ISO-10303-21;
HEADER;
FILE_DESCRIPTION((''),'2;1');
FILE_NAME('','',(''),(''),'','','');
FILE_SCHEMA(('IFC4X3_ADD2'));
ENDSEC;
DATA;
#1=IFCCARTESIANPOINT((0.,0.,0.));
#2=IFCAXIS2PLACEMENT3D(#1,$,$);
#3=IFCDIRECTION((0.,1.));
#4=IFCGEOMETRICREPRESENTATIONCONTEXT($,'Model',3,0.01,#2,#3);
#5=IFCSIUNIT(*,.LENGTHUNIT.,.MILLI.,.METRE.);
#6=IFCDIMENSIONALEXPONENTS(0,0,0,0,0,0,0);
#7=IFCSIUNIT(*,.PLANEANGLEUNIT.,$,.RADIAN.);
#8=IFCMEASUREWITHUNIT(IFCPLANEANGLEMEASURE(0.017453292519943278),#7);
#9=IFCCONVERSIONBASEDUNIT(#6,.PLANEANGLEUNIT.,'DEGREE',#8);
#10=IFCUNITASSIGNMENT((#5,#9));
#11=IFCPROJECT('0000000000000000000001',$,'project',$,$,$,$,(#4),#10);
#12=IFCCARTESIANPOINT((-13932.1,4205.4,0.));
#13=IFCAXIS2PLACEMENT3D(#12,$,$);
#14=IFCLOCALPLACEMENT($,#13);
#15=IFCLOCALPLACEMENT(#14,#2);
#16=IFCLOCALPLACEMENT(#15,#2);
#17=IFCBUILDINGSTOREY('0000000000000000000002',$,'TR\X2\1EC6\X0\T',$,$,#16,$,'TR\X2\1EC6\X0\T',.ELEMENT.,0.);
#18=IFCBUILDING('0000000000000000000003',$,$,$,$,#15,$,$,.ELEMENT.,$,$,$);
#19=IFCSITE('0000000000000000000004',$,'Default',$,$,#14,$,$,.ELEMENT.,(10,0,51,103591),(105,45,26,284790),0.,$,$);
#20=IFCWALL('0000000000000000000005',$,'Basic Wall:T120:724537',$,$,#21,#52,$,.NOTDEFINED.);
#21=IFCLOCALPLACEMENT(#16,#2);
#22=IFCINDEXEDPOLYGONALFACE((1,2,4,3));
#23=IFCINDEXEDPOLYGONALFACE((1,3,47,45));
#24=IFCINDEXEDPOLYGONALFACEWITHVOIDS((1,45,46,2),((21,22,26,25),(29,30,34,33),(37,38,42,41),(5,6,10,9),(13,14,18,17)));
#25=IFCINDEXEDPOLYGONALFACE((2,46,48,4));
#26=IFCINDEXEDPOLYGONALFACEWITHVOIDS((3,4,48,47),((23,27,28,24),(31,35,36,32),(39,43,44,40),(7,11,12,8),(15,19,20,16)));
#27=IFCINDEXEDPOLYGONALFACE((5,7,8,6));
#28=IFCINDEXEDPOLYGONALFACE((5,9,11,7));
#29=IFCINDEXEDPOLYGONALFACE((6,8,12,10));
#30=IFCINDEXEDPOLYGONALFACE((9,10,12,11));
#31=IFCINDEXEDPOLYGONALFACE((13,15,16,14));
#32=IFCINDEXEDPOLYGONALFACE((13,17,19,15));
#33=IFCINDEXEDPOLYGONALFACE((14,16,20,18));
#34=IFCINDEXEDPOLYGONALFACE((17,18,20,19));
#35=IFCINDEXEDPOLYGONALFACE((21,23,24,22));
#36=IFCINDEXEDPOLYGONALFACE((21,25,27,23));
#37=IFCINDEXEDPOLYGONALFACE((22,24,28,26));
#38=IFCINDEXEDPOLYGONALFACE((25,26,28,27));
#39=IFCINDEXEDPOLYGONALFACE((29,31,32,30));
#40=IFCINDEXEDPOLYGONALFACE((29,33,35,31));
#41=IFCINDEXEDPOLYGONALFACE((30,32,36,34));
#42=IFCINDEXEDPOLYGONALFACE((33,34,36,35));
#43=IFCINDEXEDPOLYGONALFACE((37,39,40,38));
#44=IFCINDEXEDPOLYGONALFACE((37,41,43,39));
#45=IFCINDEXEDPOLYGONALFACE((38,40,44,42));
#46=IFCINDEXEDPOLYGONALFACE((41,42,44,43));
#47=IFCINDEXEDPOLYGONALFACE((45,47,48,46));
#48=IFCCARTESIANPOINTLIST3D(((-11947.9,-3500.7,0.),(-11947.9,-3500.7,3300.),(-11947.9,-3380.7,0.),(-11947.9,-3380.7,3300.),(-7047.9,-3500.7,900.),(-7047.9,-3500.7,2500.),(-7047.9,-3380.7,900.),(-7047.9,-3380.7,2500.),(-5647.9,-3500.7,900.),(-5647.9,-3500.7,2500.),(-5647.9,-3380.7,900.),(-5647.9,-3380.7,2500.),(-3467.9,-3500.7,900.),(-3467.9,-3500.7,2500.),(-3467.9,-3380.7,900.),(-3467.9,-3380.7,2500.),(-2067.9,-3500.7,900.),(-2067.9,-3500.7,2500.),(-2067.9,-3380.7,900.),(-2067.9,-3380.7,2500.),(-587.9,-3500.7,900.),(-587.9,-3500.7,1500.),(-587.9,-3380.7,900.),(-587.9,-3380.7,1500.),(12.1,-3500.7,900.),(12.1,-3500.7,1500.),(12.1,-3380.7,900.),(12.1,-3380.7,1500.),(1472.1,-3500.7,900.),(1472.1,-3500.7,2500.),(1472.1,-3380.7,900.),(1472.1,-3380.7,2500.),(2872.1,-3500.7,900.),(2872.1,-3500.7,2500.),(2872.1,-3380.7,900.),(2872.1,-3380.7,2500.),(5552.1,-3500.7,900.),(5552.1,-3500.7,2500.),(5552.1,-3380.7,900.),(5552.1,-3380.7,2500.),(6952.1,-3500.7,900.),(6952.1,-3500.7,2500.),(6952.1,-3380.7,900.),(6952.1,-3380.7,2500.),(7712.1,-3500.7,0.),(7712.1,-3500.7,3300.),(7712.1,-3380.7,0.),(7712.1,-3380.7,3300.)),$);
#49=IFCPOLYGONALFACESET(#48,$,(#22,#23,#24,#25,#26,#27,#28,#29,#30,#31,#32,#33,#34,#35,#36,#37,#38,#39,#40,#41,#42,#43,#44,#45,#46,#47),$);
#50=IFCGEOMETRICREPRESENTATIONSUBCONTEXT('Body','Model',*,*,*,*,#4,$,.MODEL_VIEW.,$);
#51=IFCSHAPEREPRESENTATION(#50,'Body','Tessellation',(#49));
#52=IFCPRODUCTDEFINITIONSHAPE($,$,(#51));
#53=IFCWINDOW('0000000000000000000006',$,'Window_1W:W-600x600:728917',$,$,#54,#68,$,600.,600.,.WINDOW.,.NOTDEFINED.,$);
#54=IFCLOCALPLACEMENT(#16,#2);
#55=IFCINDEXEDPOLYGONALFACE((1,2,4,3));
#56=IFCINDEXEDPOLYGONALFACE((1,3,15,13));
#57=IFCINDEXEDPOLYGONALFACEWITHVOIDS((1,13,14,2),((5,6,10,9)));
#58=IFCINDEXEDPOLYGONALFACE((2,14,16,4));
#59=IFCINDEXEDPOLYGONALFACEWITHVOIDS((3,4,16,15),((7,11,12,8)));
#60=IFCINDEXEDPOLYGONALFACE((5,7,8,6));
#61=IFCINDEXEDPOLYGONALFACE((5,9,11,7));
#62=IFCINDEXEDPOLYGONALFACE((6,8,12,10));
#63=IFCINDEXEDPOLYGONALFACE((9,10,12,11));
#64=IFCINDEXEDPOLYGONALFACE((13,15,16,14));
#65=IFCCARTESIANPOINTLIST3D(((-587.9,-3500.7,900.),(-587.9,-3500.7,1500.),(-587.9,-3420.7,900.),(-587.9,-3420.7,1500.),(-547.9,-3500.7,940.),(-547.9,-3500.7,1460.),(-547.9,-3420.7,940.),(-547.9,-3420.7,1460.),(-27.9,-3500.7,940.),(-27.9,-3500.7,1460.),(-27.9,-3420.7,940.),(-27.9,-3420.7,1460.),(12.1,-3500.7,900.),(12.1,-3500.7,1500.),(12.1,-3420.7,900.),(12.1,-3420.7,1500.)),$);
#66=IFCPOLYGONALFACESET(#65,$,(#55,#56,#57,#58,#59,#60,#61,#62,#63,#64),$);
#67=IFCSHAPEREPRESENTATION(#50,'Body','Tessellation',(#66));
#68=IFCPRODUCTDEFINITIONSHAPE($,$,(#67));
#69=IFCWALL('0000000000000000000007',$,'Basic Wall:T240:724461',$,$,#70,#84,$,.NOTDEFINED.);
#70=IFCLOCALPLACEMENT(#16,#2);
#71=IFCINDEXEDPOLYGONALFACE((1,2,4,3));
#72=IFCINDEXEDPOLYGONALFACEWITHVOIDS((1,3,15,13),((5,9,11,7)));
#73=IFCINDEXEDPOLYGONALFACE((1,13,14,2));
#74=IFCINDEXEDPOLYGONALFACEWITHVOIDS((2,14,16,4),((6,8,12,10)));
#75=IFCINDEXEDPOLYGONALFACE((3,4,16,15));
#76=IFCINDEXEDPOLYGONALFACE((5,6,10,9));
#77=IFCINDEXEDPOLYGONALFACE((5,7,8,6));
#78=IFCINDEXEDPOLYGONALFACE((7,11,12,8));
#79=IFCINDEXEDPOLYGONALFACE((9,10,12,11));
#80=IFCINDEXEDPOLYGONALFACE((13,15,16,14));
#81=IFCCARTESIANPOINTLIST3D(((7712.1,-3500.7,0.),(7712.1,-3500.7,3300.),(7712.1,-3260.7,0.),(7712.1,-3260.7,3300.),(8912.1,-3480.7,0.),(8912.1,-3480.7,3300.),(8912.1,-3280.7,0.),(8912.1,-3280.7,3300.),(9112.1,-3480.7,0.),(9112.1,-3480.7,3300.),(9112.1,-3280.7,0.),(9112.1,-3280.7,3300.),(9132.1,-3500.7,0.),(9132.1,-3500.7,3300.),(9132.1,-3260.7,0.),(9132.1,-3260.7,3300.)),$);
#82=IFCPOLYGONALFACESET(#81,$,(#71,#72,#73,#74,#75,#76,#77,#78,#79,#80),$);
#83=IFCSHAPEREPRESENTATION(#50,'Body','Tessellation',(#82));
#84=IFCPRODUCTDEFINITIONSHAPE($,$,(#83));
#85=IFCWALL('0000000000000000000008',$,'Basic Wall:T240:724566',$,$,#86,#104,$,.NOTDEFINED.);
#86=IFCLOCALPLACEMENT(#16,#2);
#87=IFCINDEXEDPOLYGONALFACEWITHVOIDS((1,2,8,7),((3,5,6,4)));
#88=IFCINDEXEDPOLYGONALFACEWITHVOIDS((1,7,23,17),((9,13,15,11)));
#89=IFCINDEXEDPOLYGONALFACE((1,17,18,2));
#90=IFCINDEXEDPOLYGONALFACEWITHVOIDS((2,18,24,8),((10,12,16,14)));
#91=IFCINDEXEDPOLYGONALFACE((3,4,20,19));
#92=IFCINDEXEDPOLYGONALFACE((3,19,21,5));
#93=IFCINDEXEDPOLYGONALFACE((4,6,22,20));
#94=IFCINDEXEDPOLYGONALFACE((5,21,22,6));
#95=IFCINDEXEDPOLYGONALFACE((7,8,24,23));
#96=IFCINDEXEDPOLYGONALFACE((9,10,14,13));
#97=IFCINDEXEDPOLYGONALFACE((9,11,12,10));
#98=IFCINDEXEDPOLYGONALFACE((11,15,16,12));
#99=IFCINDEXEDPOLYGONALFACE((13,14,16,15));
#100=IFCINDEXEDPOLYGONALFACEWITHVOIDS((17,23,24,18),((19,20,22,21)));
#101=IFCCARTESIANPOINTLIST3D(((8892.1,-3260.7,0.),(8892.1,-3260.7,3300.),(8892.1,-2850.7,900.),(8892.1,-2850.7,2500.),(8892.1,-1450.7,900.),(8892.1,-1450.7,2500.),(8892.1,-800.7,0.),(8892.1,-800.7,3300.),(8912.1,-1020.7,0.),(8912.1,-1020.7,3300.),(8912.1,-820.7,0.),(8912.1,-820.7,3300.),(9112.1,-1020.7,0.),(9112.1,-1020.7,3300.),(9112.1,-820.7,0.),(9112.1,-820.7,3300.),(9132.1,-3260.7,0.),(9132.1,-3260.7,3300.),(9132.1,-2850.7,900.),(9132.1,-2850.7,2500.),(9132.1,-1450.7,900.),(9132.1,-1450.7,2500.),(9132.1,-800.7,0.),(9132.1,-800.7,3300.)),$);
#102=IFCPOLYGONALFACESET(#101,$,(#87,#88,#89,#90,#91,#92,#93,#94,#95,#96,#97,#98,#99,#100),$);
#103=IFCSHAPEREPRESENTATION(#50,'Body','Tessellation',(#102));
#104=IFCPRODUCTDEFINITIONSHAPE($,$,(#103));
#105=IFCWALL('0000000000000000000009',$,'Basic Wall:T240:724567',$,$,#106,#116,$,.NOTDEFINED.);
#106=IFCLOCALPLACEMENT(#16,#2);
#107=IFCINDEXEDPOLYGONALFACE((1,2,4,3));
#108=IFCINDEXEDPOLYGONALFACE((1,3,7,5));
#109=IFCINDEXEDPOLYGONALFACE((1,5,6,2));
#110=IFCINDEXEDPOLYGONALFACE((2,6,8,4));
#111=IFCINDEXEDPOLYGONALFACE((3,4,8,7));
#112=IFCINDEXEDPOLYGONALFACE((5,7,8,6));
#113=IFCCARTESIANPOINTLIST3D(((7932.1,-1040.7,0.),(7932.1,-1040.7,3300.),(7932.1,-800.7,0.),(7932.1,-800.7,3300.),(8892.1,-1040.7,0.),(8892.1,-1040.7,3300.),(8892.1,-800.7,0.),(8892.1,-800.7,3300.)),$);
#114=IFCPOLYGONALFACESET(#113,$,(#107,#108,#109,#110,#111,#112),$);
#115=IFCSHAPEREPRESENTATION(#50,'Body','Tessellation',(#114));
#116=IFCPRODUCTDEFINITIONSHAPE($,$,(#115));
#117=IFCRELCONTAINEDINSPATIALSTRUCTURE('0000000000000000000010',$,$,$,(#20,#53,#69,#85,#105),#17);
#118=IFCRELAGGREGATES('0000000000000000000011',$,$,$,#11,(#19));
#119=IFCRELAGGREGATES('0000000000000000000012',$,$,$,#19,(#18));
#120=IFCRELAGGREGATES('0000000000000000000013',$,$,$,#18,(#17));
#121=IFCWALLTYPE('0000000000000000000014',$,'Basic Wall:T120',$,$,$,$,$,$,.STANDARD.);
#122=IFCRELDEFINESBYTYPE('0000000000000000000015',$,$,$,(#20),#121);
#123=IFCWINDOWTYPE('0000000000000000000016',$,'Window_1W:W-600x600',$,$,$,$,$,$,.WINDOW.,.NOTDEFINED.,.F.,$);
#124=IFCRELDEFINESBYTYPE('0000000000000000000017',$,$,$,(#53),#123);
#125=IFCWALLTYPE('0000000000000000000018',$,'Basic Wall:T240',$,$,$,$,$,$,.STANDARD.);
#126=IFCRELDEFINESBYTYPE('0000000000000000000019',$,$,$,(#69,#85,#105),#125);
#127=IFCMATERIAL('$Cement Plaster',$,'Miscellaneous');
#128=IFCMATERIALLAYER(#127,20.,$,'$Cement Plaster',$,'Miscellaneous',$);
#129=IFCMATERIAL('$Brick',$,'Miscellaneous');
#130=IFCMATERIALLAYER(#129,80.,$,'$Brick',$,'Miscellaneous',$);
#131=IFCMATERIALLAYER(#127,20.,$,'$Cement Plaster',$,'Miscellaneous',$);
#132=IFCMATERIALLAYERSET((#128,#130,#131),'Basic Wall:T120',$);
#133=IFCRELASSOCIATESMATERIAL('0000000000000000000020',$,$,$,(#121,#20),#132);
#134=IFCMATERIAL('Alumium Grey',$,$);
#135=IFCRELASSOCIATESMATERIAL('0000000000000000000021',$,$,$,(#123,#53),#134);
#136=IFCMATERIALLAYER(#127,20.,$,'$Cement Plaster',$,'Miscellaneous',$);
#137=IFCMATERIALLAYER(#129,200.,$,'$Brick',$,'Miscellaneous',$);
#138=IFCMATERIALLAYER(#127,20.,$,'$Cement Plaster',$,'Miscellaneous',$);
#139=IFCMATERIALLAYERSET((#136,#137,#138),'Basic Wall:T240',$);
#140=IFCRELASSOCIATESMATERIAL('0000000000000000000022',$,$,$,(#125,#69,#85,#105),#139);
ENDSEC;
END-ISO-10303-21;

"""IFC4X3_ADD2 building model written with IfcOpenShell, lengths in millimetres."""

from ifc_helpers import new_model, entity, si_unit, converted_unit, direction, frame, frame_2d, origin, origin_2d_with_axis, place, context, subcontext, project, spatial, polyline, rectangle, outline, extrude, source, transform, mapped, material, layer, layer_set, type_object, type_shapes, element, fill, save


model = new_model("IFC4X3_ADD2")

# Units and contexts
model_context = context("Model", 3, precision=0.01, world=origin(), true_north=direction((0.0, 1.0)))
body_context = subcontext(model_context, "Body", "Model", "MODEL_VIEW")
ifc_project = project(units=[si_unit("LENGTHUNIT", "METRE", prefix="MILLI"), converted_unit("PLANEANGLEUNIT", "DEGREE", entity("IfcPlaneAngleMeasure", 0.017453292519943278), si_unit("PLANEANGLEUNIT", "RADIAN"), dimensions=[0, 0, 0, 0, 0, 0, 0])], contexts=[model_context])

# Site, building, storey
site_placement = place(None, frame((-13932.1, 4205.4, 0.0)))
site = spatial("IfcSite", under=ifc_project, at=site_placement, Name="Default", CompositionType="ELEMENT", RefLatitude=(10, 0, 51, 103591), RefLongitude=(105, 45, 26, 284790), RefElevation=0.0)
building_placement = place(site_placement, origin())
building = spatial("IfcBuilding", under=site, at=building_placement, CompositionType="ELEMENT")
storey_placement = place(building_placement, origin())
storey = spatial("IfcBuildingStorey", under=building, at=storey_placement, Name="TRỆT", LongName="TRỆT", CompositionType="ELEMENT", Elevation=0.0)

# Shared definitions
ifc_material_1 = material(Name="$Cement Plaster", Category="Miscellaneous")
ifc_layer_1 = layer(ifc_material_1, 20.0, Name="$Cement Plaster", Category="Miscellaneous")
ifc_material_2 = material(Name="$Brick", Category="Miscellaneous")
ifc_layer_2 = layer(ifc_material_2, 80.0, Name="$Brick", Category="Miscellaneous")
ifc_layer_3 = layer(ifc_material_1, 20.0, Name="$Cement Plaster", Category="Miscellaneous")
ifc_layer_set_1 = layer_set([ifc_layer_1, ifc_layer_2, ifc_layer_3], Name="Basic Wall:T120")
wall_type_1 = type_object("IfcWallType", Name="Basic Wall:T120", PredefinedType="STANDARD", material=ifc_layer_set_1)

# Wall, openings, window
wall_1_placement = place(storey_placement, frame((7712.1, -3440.7, 0.0), z_axis=(0.0, 0.0, 1.0), x_axis=(-1.0, 0.0, 0.0)))
wall_1 = element("IfcWall", 1, at=wall_1_placement, inside=storey, type_object=wall_type_1, material=ifc_layer_set_1, Name="Basic Wall:T120:724537", PredefinedType="NOTDEFINED", context=body_context, shape_type="SweptSolid", body=[
    extrude(rectangle(XDim=19660.0, YDim=120.0, at=frame_2d((9830.0, 0.0), x_axis=(-1.0, 0.0))), origin(), (0.0, 0.0, 1.0), 3300.0),
])
opening_1_placement = place(wall_1_placement, frame((9780.0, -60.0, 900.0)))
element("IfcOpeningElement", 2, at=opening_1_placement, cuts=wall_1, PredefinedType="OPENING", context=body_context, shape_type="SweptSolid", body=[
    extrude(rectangle(XDim=1600.0, YDim=1400.0, at=frame_2d((800.0, 700.0), x_axis=(1.0, 0.0))), frame((0.0, 0.0, 0.0), z_axis=(0.0, 1.0, 0.0), x_axis=(0.0, 0.0, 1.0)), (0.0, 0.0, 1.0), 120.0),
])
opening_2_placement = place(wall_1_placement, frame((13360.0, -60.0, 900.0)))
element("IfcOpeningElement", 3, at=opening_2_placement, cuts=wall_1, PredefinedType="OPENING", context=body_context, shape_type="SweptSolid", body=[
    extrude(rectangle(XDim=1600.0, YDim=1400.0, at=frame_2d((800.0, 700.0), x_axis=(1.0, 0.0))), frame((0.0, 0.0, 0.0), z_axis=(0.0, 1.0, 0.0), x_axis=(0.0, 0.0, 1.0)), (0.0, 0.0, 1.0), 120.0),
])
opening_3_placement = place(wall_1_placement, frame((4840.0, -60.0, 900.0)))
element("IfcOpeningElement", 4, at=opening_3_placement, cuts=wall_1, PredefinedType="OPENING", context=body_context, shape_type="SweptSolid", body=[
    extrude(rectangle(XDim=1600.0, YDim=1400.0, at=frame_2d((800.0, 700.0), x_axis=(1.0, 0.0))), frame((0.0, 0.0, 0.0), z_axis=(0.0, 1.0, 0.0), x_axis=(0.0, 0.0, 1.0)), (0.0, 0.0, 1.0), 120.0),
])
opening_4_placement = place(wall_1_placement, frame((760.0, -60.0, 900.0)))
element("IfcOpeningElement", 5, at=opening_4_placement, cuts=wall_1, PredefinedType="OPENING", context=body_context, shape_type="SweptSolid", body=[
    extrude(rectangle(XDim=1600.0, YDim=1400.0, at=frame_2d((800.0, 700.0), x_axis=(1.0, 0.0))), frame((0.0, 0.0, 0.0), z_axis=(0.0, 1.0, 0.0), x_axis=(0.0, 0.0, 1.0)), (0.0, 0.0, 1.0), 120.0),
])
opening_5_placement = place(wall_1_placement, frame((7700.0, -60.0, 900.0)))
opening_5 = element("IfcOpeningElement", 6, at=opening_5_placement, cuts=wall_1, PredefinedType="OPENING", context=body_context, shape_type="SweptSolid", body=[
    extrude(rectangle(XDim=600.0, YDim=600.0, at=frame_2d((300.0, 300.0), x_axis=(1.0, 0.0))), frame((0.0, 0.0, 0.0), z_axis=(0.0, 1.0, 0.0), x_axis=(0.0, 0.0, 1.0)), (0.0, 0.0, 1.0), 120.0),
])
ifc_material_3 = material(Name="Alumium Grey")
window_type = type_object("IfcWindowType", Name="Window_1W:W-600x600", ParameterTakesPrecedence=False, PartitioningType="NOTDEFINED", PredefinedType="WINDOW", material=ifc_material_3)
shared_shape_1 = source(origin(), body_context, "Body", "SweptSolid", [
    extrude(outline(polyline([(-300.0, -300.0), (300.0, -300.0), (300.0, 300.0), (-300.0, 300.0), (-300.0, -300.0)]), holes=[polyline([(-260.0, -260.0), (-260.0, 260.0), (260.0, 260.0), (260.0, -260.0), (-260.0, -260.0)])]), frame((300.0, 120.0, 300.0), z_axis=(0.0, -1.0, 0.0), x_axis=(-1.0, 0.0, 0.0)), (0.0, 0.0, 1.0), 80.0),
])
type_shapes(window_type, [shared_shape_1])
window_placement = place(opening_5_placement, origin())
window = element("IfcWindow", 7, at=window_placement, inside=storey, type_object=window_type, material=ifc_material_3, Name="Window_1W:W-600x600:728917", OverallHeight=600.0, OverallWidth=600.0, PartitioningType="NOTDEFINED", PredefinedType="WINDOW", context=body_context, shape_type="MappedRepresentation", body=[
    mapped(shared_shape_1, transform((0.0, 0.0, 0.0), scale=1.0)),
])
fill(opening_5, window)

# Wall, opening
ifc_layer_4 = layer(ifc_material_1, 20.0, Name="$Cement Plaster", Category="Miscellaneous")
ifc_layer_5 = layer(ifc_material_2, 200.0, Name="$Brick", Category="Miscellaneous")
ifc_layer_6 = layer(ifc_material_1, 20.0, Name="$Cement Plaster", Category="Miscellaneous")
ifc_layer_set_2 = layer_set([ifc_layer_4, ifc_layer_5, ifc_layer_6], Name="Basic Wall:T240")
wall_type_2 = type_object("IfcWallType", Name="Basic Wall:T240", PredefinedType="STANDARD", material=ifc_layer_set_2)
wall_2_placement = place(storey_placement, frame((9132.1, -3380.7, 0.0), z_axis=(0.0, 0.0, 1.0), x_axis=(-1.0, 0.0, 0.0)))
wall_2 = element("IfcWall", 8, at=wall_2_placement, inside=storey, type_object=wall_type_2, material=ifc_layer_set_2, Name="Basic Wall:T240:724461", PredefinedType="NOTDEFINED", context=body_context, shape_type="SweptSolid", body=[
    extrude(rectangle(XDim=1420.0, YDim=240.0, at=frame_2d((710.0, 0.0), x_axis=(-1.0, 0.0))), origin(), (0.0, 0.0, 1.0), 3300.0),
])
opening_6_placement = place(storey_placement, frame((9132.1, -3380.7, 0.0), z_axis=(0.0, 0.0, 1.0), x_axis=(-1.0, 0.0, 0.0)))
element("IfcOpeningElement", 9, at=opening_6_placement, cuts=wall_2, PredefinedType="OPENING", context=body_context, shape_type="SweptSolid", body=[
    extrude(rectangle(XDim=3300.0, YDim=200.0, at=origin_2d_with_axis()), frame((220.0, 0.0, 1650.0), z_axis=(-1.0, 0.0, 0.0), x_axis=(0.0, 0.0, 1.0)), (0.0, 0.0, 1.0), 200.0),
])

# Wall, openings
wall_3_placement = place(storey_placement, frame((9012.1, -3260.7, 0.0), z_axis=(0.0, 0.0, 1.0), x_axis=(0.0, 1.0, 0.0)))
wall_3 = element("IfcWall", 10, at=wall_3_placement, inside=storey, type_object=wall_type_2, material=ifc_layer_set_2, Name="Basic Wall:T240:724566", PredefinedType="NOTDEFINED", context=body_context, shape_type="SweptSolid", body=[
    extrude(rectangle(XDim=2460.0, YDim=240.0, at=frame_2d((1230.0, 0.0), x_axis=(-1.0, 0.0))), origin(), (0.0, 0.0, 1.0), 3300.0),
])
opening_7_placement = place(storey_placement, frame((9012.1, -3260.7, 0.0), z_axis=(0.0, 0.0, 1.0), x_axis=(0.0, 1.0, 0.0)))
element("IfcOpeningElement", 11, at=opening_7_placement, cuts=wall_3, PredefinedType="OPENING", context=body_context, shape_type="SweptSolid", body=[
    extrude(rectangle(XDim=3300.0, YDim=200.0, at=frame_2d((0.0, 0.0), x_axis=(1.0, 0.0))), frame((2340.0, 100.0, 1650.0), z_axis=(0.0, -1.0, 0.0), x_axis=(0.0, 0.0, 1.0)), (0.0, 0.0, 1.0), 200.0),
])
opening_8_placement = place(wall_3_placement, frame((1810.0, 120.0, 900.0)))
element("IfcOpeningElement", 12, at=opening_8_placement, cuts=wall_3, PredefinedType="OPENING", context=body_context, shape_type="SweptSolid", body=[
    extrude(rectangle(XDim=1600.0, YDim=1400.0, at=frame_2d((800.0, 700.0), x_axis=(1.0, 0.0))), frame((0.0, 0.0, 0.0), z_axis=(0.0, -1.0, 0.0), x_axis=(0.0, 0.0, 1.0)), (0.0, 0.0, 1.0), 240.0),
])

# Wall
wall_4_placement = place(storey_placement, frame((8892.1, -920.7, 0.0), z_axis=(0.0, 0.0, 1.0), x_axis=(-1.0, 0.0, 0.0)))
element("IfcWall", 13, at=wall_4_placement, inside=storey, type_object=wall_type_2, material=ifc_layer_set_2, Name="Basic Wall:T240:724567", PredefinedType="NOTDEFINED", context=body_context, shape_type="SweptSolid", body=[
    extrude(rectangle(XDim=960.0, YDim=240.0, at=frame_2d((480.0, 0.0), x_axis=(-1.0, 0.0))), origin(), (0.0, 0.0, 1.0), 3300.0),
])

save(model, "model.ifc")
